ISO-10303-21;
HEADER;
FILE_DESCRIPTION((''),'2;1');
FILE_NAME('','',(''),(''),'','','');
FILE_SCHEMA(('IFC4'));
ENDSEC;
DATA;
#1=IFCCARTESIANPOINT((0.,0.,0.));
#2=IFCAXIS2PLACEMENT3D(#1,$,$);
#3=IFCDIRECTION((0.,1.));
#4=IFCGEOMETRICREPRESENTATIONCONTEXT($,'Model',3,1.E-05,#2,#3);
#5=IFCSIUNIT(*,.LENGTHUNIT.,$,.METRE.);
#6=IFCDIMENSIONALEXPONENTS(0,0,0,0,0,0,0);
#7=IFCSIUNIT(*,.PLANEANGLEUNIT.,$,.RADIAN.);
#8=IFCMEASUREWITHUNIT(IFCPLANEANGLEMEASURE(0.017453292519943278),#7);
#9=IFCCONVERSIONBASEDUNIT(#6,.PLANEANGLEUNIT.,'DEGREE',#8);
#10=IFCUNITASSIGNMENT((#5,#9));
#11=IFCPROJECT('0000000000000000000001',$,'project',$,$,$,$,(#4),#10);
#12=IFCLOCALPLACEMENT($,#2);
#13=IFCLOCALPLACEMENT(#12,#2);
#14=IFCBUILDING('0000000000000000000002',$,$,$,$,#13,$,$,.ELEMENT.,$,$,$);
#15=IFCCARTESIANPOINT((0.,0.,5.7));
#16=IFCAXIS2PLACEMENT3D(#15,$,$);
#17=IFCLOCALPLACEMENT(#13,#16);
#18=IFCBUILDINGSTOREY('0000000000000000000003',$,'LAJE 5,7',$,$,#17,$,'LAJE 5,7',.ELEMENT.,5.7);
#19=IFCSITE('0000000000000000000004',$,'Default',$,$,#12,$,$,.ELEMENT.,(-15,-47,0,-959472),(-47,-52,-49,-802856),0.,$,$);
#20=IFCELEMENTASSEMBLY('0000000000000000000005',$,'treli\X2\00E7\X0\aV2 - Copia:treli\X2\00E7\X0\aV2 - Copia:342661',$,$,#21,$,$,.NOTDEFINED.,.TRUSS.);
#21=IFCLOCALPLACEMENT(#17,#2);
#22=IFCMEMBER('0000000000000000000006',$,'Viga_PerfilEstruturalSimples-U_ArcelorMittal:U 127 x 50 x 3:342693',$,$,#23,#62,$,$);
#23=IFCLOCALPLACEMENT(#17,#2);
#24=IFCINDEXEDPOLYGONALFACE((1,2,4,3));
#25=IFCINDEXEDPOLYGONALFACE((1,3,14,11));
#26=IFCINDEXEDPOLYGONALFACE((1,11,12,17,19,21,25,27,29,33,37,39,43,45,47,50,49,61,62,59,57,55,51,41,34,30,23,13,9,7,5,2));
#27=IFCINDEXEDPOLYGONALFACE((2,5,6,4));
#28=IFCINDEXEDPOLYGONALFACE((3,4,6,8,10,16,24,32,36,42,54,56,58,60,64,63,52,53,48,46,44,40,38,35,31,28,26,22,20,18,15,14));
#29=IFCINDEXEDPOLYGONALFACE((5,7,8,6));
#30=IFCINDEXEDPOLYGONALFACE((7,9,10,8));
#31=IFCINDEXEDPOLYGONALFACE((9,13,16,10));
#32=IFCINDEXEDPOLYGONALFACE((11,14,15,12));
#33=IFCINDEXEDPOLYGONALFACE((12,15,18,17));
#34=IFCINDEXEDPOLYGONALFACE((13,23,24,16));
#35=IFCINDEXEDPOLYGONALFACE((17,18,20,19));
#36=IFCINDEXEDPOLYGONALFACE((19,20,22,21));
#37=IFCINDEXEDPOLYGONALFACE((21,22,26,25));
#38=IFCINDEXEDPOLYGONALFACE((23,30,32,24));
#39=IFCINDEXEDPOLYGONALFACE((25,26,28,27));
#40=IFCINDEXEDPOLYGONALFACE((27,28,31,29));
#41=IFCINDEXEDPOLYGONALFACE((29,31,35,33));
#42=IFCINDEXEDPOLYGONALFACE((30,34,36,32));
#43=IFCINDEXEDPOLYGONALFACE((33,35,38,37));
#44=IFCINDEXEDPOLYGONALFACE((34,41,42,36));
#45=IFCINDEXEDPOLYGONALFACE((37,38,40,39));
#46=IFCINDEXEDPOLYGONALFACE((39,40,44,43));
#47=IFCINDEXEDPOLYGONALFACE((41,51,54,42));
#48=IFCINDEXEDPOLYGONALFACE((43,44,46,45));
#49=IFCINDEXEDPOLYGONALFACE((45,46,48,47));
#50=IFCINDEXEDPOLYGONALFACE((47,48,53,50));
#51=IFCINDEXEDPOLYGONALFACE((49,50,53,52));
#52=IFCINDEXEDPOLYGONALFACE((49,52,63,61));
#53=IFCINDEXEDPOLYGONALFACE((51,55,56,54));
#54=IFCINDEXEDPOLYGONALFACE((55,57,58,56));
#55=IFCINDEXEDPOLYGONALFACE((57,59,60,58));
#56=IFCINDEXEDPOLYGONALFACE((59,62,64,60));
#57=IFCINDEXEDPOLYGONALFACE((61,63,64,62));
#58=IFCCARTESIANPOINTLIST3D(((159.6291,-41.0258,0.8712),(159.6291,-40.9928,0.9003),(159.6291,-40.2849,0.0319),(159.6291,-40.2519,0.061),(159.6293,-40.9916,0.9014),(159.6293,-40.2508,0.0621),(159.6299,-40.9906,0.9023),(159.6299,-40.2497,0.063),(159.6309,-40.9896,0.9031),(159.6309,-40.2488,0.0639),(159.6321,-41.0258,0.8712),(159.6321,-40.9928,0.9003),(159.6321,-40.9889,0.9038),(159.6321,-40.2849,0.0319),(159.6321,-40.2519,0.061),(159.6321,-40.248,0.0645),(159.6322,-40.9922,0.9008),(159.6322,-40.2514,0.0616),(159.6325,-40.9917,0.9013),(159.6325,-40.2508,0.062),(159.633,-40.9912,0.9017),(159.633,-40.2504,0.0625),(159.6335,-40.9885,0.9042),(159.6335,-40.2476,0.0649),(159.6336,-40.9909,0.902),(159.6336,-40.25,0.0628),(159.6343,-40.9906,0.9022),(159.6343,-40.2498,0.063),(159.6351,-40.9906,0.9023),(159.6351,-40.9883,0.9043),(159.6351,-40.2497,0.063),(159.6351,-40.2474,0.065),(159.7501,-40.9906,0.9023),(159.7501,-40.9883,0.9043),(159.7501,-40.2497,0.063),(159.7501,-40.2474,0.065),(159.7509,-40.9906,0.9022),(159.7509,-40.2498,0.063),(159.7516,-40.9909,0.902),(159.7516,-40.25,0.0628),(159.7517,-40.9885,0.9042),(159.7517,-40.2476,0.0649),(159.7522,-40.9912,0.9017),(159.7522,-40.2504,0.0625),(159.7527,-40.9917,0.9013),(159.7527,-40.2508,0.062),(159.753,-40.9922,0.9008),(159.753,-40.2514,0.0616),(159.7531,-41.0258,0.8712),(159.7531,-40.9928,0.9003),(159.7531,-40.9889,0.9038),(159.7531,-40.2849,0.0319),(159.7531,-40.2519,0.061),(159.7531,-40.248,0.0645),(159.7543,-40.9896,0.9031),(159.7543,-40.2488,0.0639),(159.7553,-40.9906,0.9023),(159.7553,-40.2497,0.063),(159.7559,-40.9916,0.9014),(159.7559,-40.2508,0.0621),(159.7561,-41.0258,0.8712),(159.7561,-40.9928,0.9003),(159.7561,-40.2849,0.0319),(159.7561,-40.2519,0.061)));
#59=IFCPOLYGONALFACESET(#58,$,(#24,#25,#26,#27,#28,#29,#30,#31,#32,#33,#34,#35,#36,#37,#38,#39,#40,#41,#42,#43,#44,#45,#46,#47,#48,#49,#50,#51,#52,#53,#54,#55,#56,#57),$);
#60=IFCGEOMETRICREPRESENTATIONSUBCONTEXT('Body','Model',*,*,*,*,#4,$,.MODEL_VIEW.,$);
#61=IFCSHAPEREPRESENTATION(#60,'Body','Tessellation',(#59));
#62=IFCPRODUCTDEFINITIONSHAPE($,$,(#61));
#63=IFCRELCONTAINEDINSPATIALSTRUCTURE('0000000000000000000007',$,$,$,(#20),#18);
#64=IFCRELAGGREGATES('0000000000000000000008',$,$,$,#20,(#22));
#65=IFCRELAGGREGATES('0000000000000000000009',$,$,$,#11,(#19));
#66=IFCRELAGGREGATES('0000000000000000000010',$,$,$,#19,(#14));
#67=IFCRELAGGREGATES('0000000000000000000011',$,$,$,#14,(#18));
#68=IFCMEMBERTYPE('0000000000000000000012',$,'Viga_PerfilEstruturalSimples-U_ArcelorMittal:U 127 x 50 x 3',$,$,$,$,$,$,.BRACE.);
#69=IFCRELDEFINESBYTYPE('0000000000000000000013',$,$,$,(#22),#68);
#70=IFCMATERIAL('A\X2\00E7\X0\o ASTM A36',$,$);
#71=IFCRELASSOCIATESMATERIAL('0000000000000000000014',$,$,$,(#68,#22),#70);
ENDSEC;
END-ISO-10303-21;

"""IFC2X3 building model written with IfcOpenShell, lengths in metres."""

from ifc_helpers import new_model, entity, si_unit, converted_unit, direction, frame, frame_2d, origin, place, context, subcontext, project, spatial, polyline, circle_curve, parameter, trimmed, segment, composite_curve, outline, extrude, source, transform, mapped, material, type_object, type_shapes, element, aggregate, save


model = new_model("IFC2X3")

# Units and contexts
model_context = context("Model", 3, precision=1e-05, world=origin(), true_north=direction((0.0, 1.0)))
body_context = subcontext(model_context, "Body", "Model", "MODEL_VIEW")
ifc_project = project(units=[si_unit("LENGTHUNIT", "METRE"), converted_unit("PLANEANGLEUNIT", "DEGREE", entity("IfcPlaneAngleMeasure", 0.017453292519943278), si_unit("PLANEANGLEUNIT", "RADIAN"), dimensions=[0, 0, 0, 0, 0, 0, 0])], contexts=[model_context])

# Site, building, storey
site_placement = place(None, origin())
site = spatial("IfcSite", under=ifc_project, at=site_placement, Name="Default", CompositionType="ELEMENT", RefLatitude=(-15, -47, 0, -959472), RefLongitude=(-47, -52, -49, -802856), RefElevation=0.0)
building_placement = place(site_placement, origin())
building = spatial("IfcBuilding", under=site, at=building_placement, CompositionType="ELEMENT")
storey_placement = place(building_placement, frame((0.0, 0.0, 5.7)))
storey = spatial("IfcBuildingStorey", under=building, at=storey_placement, Name="LAJE 5,7", LongName="LAJE 5,7", CompositionType="ELEMENT", Elevation=5.7)

# Element assembly
ifc_material = material(Name="Aço ASTM A36")
assembly_1_placement = place(storey_placement, origin())
assembly_1 = element("IfcElementAssembly", 1, at=assembly_1_placement, inside=storey, Name="treliçaV2 - Copia:treliçaV2 - Copia:342661", AssemblyPlace="NOTDEFINED", PredefinedType="TRUSS")

# Member
member_type_1 = type_object("IfcMemberType", Name="Viga_PerfilEstruturalSimples-U_ArcelorMittal:U 127 x 50 x 3", PredefinedType="BRACE", material=ifc_material)
shared_shape_1 = source(origin(), body_context, "Body", "SweptSolid", [
    extrude(outline(composite_curve([segment(polyline([(-0.0575, -0.0192), (0.0575, -0.0192)]), True, "CONTINUOUS"), segment(trimmed(circle_curve(frame_2d((0.0575, -0.0132), x_axis=(0.0, 1.0)), 0.006), [parameter(180.0)], [parameter(270.0)], True, "PARAMETER"), True, "CONTINUOUS"), segment(polyline([(0.0635, -0.0132), (0.0635, 0.0308)]), True, "CONTINUOUS"), segment(polyline([(0.0635, 0.0308), (0.0605, 0.0308)]), True, "CONTINUOUS"), segment(polyline([(0.0605, 0.0308), (0.0605, -0.0132)]), True, "CONTINUOUS"), segment(trimmed(circle_curve(frame_2d((0.0575, -0.0132), x_axis=(0.0, 1.0)), 0.003), [parameter(180.0)], [parameter(270.0)], True, "PARAMETER"), False, "CONTINUOUS"), segment(polyline([(0.0575, -0.0162), (-0.0575, -0.0162)]), True, "CONTINUOUS"), segment(trimmed(circle_curve(frame_2d((-0.0575, -0.0132), x_axis=(0.0, 1.0)), 0.003), [parameter(90.0)], [parameter(180.0)], True, "PARAMETER"), False, "CONTINUOUS"), segment(polyline([(-0.0605, -0.0132), (-0.0605, 0.0308)]), True, "CONTINUOUS"), segment(polyline([(-0.0605, 0.0308), (-0.0635, 0.0308)]), True, "CONTINUOUS"), segment(polyline([(-0.0635, 0.0308), (-0.0635, -0.0132)]), True, "CONTINUOUS"), segment(trimmed(circle_curve(frame_2d((-0.0575, -0.0132), x_axis=(0.0, 1.0)), 0.006), [parameter(90.0)], [parameter(180.0)], True, "PARAMETER"), True, "CONTINUOUS")], self_intersect=False)), frame((-0.5514, -0.0058, 0.0), z_axis=(1.0, 0.0, 0.0), x_axis=(0.0, 0.0, -1.0)), (0.0, 0.0, 1.0), 1.1195),
])
type_shapes(member_type_1, [shared_shape_1])
member_1_placement = place(assembly_1_placement, frame((159.6926, -40.6421, 0.4744), z_axis=(-1.0, 0.0, 0.0), x_axis=(0.0, 0.661783, -0.749695)))
member_1 = element("IfcMember", 2, at=member_1_placement, type_object=member_type_1, material=ifc_material, Name="Viga_PerfilEstruturalSimples-U_ArcelorMittal:U 127 x 50 x 3:342693", context=body_context, shape_type="MappedRepresentation", body=[
    mapped(shared_shape_1, transform((0.0, 0.0, 0.0), scale=1.0)),
])
aggregate(assembly_1, [member_1])

save(model, "model.ifc")
